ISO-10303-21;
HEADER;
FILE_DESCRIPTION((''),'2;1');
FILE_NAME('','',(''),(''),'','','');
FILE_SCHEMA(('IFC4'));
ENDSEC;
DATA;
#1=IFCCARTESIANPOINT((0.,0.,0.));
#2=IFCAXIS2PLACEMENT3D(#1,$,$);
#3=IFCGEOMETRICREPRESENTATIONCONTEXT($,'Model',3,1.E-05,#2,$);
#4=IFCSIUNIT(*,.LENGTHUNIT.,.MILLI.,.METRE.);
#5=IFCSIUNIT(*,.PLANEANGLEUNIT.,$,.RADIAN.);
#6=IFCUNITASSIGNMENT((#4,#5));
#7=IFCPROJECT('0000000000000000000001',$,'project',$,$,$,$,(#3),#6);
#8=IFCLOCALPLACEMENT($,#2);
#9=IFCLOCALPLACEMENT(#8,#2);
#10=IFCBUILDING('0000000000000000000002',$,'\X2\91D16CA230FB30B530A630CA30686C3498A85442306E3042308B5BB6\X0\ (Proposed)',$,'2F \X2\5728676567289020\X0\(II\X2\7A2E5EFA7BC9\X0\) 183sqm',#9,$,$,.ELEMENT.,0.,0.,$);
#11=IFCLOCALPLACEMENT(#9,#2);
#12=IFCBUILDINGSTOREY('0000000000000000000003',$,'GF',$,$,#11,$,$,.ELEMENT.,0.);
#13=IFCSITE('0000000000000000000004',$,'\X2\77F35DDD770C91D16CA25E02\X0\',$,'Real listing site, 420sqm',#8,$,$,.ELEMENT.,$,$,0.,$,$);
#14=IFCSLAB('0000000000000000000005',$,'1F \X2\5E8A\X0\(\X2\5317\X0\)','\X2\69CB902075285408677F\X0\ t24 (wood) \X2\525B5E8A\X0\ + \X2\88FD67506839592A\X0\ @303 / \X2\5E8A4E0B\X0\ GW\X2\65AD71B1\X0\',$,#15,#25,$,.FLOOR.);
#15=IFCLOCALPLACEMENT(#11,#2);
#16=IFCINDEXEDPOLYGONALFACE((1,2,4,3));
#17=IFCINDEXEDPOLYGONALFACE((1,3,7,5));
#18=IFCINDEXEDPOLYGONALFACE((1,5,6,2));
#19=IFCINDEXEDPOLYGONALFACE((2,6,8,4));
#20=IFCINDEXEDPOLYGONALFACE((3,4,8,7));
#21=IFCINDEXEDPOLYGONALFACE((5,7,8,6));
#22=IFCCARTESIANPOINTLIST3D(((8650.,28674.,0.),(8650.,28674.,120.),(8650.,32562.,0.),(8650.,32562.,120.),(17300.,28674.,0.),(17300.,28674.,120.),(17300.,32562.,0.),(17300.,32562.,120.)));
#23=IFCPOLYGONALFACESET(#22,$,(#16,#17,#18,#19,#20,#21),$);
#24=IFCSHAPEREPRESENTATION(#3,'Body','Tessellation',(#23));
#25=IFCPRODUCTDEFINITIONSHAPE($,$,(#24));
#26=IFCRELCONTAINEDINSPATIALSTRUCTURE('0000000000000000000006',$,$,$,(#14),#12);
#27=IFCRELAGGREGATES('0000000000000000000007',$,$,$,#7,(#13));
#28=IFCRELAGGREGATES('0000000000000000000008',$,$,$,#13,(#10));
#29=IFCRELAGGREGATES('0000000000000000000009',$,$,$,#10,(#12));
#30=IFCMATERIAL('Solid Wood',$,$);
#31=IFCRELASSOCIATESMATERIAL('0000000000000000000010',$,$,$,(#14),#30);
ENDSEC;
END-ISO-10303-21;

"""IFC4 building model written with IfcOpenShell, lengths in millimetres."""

from ifc_helpers import new_model, si_unit, frame, frame_2d, origin, place, context, project, spatial, rectangle, extrude, material, element, save


model = new_model("IFC4")

# Units and contexts
model_context = context("Model", 3, precision=1e-05, world=origin())
ifc_project = project(units=[si_unit("LENGTHUNIT", "METRE", prefix="MILLI"), si_unit("PLANEANGLEUNIT", "RADIAN")], contexts=[model_context])

# Site, building, storey
site_placement = place(None, origin())
site = spatial("IfcSite", under=ifc_project, at=site_placement, Name="石川県金沢市", ObjectType="Real listing site, 420sqm", CompositionType="ELEMENT", RefElevation=0.0)
building_placement = place(site_placement, origin())
building = spatial("IfcBuilding", under=site, at=building_placement, Name="金沢・サウナと水風呂のある家 (Proposed)", ObjectType="2F 在来木造(II種建築) 183sqm", CompositionType="ELEMENT", ElevationOfRefHeight=0.0, ElevationOfTerrain=0.0)
storey_placement = place(building_placement, origin())
storey = spatial("IfcBuildingStorey", under=building, at=storey_placement, Name="GF", CompositionType="ELEMENT", Elevation=0.0)

# Shared definitions
ifc_material_1 = material(Name="Solid Wood")

# Slab
slab_1_placement = place(storey_placement, frame((4325.0, 14337.0, 0.0)))
element("IfcSlab", 1, at=slab_1_placement, inside=storey, material=ifc_material_1, Name="1F 床(北)", Description="構造用合板 t24 (wood) 剛床 + 製材根太 @303 / 床下 GW断熱", PredefinedType="FLOOR", context=model_context, shape_type="SweptSolid", body=[
    extrude(rectangle(XDim=8650.0, YDim=3888.0, at=frame_2d((4325.0, 1944.0))), frame((4325.0, 14337.0, 0.0)), (0.0, 0.0, 1.0), 120.0),
])

save(model, "model.ifc")
